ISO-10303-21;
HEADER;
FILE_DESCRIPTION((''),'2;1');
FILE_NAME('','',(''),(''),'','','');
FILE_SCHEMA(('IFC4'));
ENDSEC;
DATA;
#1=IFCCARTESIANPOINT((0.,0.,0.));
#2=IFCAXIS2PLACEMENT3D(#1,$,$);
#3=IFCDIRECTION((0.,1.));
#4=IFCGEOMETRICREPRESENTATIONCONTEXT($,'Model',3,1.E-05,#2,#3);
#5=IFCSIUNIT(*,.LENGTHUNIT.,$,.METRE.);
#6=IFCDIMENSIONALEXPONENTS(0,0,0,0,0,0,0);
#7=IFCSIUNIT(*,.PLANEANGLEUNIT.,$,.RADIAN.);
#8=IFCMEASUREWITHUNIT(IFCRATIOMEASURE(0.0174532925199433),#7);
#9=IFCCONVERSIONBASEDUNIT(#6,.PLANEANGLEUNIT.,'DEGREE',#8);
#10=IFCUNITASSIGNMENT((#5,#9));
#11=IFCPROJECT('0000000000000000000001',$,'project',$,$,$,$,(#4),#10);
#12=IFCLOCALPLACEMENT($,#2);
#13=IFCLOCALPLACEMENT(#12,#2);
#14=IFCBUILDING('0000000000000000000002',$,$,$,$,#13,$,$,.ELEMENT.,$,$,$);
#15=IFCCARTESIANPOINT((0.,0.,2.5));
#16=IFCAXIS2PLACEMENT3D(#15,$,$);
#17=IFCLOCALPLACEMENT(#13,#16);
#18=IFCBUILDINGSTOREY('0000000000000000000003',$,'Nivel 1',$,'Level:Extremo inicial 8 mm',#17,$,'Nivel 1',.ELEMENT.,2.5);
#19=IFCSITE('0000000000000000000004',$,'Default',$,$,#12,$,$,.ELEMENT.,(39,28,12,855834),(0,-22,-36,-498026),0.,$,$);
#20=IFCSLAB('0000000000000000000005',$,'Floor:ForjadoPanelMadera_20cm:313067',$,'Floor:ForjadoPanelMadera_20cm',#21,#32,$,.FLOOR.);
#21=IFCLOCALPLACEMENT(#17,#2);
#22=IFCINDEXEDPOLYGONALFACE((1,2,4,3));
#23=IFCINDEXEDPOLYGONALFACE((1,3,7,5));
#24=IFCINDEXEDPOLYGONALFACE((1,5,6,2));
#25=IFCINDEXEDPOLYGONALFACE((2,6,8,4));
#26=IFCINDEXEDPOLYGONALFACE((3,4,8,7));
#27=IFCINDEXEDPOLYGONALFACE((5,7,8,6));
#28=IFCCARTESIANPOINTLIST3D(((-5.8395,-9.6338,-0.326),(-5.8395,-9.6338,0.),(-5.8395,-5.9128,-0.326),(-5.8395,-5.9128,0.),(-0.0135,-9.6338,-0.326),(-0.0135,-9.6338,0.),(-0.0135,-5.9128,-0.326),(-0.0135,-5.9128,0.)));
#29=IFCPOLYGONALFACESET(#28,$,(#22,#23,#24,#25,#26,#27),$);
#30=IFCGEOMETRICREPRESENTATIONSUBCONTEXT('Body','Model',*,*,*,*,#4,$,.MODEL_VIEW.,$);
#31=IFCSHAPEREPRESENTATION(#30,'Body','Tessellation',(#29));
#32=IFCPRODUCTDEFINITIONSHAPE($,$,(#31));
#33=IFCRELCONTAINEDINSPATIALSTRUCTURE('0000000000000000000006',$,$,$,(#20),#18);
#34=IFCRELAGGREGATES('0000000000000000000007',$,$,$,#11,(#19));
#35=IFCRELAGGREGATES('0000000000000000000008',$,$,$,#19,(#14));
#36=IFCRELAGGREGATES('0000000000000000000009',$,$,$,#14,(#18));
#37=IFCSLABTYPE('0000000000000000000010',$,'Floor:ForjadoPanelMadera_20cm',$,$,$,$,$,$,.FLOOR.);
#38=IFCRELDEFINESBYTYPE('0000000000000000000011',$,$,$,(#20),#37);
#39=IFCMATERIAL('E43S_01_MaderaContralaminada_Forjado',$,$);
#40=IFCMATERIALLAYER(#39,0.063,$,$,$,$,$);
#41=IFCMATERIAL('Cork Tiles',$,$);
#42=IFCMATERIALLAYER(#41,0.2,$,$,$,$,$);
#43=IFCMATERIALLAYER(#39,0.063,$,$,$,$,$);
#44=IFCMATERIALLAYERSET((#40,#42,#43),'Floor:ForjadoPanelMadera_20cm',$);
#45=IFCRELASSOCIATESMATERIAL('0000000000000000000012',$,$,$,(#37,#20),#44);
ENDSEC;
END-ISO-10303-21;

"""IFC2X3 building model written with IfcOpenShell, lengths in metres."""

from ifc_helpers import new_model, entity, si_unit, converted_unit, direction, frame, frame_2d, origin, place, context, subcontext, project, spatial, rectangle, extrude, material, layer, layer_set, layer_usage, type_object, element, save


model = new_model("IFC2X3")

# Units and contexts
model_context = context("Model", 3, precision=1e-05, world=origin(), true_north=direction((0.0, 1.0)))
body_context = subcontext(model_context, "Body", "Model", "MODEL_VIEW")
ifc_project = project(units=[si_unit("LENGTHUNIT", "METRE"), converted_unit("PLANEANGLEUNIT", "DEGREE", entity("IfcRatioMeasure", 0.0174532925199433), si_unit("PLANEANGLEUNIT", "RADIAN"), dimensions=[0, 0, 0, 0, 0, 0, 0])], contexts=[model_context])

# Site, building, storey
site_placement = place(None, origin())
site = spatial("IfcSite", under=ifc_project, at=site_placement, Name="Default", CompositionType="ELEMENT", RefLatitude=(39, 28, 12, 855834), RefLongitude=(0, -22, -36, -498026), RefElevation=0.0)
building_placement = place(site_placement, origin())
building = spatial("IfcBuilding", under=site, at=building_placement, CompositionType="ELEMENT")
storey_placement = place(building_placement, frame((0.0, 0.0, 2.5)))
storey = spatial("IfcBuildingStorey", under=building, at=storey_placement, Name="Nivel 1", ObjectType="Level:Extremo inicial 8 mm", LongName="Nivel 1", CompositionType="ELEMENT", Elevation=2.5)

# Slab
ifc_material_1 = material(Name="E43S_01_MaderaContralaminada_Forjado")
ifc_layer_1 = layer(ifc_material_1, 0.063)
ifc_material_2 = material(Name="Cork Tiles")
ifc_layer_2 = layer(ifc_material_2, 0.2)
ifc_layer_3 = layer(ifc_material_1, 0.063)
ifc_layer_set = layer_set([ifc_layer_1, ifc_layer_2, ifc_layer_3], Name="Floor:ForjadoPanelMadera_20cm")
ifc_layer_usage = layer_usage(ifc_layer_set, "AXIS3", "POSITIVE", 0.0)
slab_type = type_object("IfcSlabType", Name="Floor:ForjadoPanelMadera_20cm", PredefinedType="FLOOR", material=ifc_layer_set)
slab_placement = place(storey_placement, origin())
element("IfcSlab", 1, at=slab_placement, inside=storey, type_object=slab_type, material=ifc_layer_usage, Name="Floor:ForjadoPanelMadera_20cm:313067", ObjectType="Floor:ForjadoPanelMadera_20cm", PredefinedType="FLOOR", context=body_context, shape_type="SweptSolid", body=[
    extrude(rectangle(XDim=3.721, YDim=5.826, at=frame_2d((0.0, 0.0), x_axis=(1.0, 0.0))), frame((-2.9265, -7.7733, 0.0), z_axis=(0.0, 0.0, -1.0), x_axis=(0.0, 1.0, 0.0)), (0.0, 0.0, 1.0), 0.326),
])

save(model, "model.ifc")
